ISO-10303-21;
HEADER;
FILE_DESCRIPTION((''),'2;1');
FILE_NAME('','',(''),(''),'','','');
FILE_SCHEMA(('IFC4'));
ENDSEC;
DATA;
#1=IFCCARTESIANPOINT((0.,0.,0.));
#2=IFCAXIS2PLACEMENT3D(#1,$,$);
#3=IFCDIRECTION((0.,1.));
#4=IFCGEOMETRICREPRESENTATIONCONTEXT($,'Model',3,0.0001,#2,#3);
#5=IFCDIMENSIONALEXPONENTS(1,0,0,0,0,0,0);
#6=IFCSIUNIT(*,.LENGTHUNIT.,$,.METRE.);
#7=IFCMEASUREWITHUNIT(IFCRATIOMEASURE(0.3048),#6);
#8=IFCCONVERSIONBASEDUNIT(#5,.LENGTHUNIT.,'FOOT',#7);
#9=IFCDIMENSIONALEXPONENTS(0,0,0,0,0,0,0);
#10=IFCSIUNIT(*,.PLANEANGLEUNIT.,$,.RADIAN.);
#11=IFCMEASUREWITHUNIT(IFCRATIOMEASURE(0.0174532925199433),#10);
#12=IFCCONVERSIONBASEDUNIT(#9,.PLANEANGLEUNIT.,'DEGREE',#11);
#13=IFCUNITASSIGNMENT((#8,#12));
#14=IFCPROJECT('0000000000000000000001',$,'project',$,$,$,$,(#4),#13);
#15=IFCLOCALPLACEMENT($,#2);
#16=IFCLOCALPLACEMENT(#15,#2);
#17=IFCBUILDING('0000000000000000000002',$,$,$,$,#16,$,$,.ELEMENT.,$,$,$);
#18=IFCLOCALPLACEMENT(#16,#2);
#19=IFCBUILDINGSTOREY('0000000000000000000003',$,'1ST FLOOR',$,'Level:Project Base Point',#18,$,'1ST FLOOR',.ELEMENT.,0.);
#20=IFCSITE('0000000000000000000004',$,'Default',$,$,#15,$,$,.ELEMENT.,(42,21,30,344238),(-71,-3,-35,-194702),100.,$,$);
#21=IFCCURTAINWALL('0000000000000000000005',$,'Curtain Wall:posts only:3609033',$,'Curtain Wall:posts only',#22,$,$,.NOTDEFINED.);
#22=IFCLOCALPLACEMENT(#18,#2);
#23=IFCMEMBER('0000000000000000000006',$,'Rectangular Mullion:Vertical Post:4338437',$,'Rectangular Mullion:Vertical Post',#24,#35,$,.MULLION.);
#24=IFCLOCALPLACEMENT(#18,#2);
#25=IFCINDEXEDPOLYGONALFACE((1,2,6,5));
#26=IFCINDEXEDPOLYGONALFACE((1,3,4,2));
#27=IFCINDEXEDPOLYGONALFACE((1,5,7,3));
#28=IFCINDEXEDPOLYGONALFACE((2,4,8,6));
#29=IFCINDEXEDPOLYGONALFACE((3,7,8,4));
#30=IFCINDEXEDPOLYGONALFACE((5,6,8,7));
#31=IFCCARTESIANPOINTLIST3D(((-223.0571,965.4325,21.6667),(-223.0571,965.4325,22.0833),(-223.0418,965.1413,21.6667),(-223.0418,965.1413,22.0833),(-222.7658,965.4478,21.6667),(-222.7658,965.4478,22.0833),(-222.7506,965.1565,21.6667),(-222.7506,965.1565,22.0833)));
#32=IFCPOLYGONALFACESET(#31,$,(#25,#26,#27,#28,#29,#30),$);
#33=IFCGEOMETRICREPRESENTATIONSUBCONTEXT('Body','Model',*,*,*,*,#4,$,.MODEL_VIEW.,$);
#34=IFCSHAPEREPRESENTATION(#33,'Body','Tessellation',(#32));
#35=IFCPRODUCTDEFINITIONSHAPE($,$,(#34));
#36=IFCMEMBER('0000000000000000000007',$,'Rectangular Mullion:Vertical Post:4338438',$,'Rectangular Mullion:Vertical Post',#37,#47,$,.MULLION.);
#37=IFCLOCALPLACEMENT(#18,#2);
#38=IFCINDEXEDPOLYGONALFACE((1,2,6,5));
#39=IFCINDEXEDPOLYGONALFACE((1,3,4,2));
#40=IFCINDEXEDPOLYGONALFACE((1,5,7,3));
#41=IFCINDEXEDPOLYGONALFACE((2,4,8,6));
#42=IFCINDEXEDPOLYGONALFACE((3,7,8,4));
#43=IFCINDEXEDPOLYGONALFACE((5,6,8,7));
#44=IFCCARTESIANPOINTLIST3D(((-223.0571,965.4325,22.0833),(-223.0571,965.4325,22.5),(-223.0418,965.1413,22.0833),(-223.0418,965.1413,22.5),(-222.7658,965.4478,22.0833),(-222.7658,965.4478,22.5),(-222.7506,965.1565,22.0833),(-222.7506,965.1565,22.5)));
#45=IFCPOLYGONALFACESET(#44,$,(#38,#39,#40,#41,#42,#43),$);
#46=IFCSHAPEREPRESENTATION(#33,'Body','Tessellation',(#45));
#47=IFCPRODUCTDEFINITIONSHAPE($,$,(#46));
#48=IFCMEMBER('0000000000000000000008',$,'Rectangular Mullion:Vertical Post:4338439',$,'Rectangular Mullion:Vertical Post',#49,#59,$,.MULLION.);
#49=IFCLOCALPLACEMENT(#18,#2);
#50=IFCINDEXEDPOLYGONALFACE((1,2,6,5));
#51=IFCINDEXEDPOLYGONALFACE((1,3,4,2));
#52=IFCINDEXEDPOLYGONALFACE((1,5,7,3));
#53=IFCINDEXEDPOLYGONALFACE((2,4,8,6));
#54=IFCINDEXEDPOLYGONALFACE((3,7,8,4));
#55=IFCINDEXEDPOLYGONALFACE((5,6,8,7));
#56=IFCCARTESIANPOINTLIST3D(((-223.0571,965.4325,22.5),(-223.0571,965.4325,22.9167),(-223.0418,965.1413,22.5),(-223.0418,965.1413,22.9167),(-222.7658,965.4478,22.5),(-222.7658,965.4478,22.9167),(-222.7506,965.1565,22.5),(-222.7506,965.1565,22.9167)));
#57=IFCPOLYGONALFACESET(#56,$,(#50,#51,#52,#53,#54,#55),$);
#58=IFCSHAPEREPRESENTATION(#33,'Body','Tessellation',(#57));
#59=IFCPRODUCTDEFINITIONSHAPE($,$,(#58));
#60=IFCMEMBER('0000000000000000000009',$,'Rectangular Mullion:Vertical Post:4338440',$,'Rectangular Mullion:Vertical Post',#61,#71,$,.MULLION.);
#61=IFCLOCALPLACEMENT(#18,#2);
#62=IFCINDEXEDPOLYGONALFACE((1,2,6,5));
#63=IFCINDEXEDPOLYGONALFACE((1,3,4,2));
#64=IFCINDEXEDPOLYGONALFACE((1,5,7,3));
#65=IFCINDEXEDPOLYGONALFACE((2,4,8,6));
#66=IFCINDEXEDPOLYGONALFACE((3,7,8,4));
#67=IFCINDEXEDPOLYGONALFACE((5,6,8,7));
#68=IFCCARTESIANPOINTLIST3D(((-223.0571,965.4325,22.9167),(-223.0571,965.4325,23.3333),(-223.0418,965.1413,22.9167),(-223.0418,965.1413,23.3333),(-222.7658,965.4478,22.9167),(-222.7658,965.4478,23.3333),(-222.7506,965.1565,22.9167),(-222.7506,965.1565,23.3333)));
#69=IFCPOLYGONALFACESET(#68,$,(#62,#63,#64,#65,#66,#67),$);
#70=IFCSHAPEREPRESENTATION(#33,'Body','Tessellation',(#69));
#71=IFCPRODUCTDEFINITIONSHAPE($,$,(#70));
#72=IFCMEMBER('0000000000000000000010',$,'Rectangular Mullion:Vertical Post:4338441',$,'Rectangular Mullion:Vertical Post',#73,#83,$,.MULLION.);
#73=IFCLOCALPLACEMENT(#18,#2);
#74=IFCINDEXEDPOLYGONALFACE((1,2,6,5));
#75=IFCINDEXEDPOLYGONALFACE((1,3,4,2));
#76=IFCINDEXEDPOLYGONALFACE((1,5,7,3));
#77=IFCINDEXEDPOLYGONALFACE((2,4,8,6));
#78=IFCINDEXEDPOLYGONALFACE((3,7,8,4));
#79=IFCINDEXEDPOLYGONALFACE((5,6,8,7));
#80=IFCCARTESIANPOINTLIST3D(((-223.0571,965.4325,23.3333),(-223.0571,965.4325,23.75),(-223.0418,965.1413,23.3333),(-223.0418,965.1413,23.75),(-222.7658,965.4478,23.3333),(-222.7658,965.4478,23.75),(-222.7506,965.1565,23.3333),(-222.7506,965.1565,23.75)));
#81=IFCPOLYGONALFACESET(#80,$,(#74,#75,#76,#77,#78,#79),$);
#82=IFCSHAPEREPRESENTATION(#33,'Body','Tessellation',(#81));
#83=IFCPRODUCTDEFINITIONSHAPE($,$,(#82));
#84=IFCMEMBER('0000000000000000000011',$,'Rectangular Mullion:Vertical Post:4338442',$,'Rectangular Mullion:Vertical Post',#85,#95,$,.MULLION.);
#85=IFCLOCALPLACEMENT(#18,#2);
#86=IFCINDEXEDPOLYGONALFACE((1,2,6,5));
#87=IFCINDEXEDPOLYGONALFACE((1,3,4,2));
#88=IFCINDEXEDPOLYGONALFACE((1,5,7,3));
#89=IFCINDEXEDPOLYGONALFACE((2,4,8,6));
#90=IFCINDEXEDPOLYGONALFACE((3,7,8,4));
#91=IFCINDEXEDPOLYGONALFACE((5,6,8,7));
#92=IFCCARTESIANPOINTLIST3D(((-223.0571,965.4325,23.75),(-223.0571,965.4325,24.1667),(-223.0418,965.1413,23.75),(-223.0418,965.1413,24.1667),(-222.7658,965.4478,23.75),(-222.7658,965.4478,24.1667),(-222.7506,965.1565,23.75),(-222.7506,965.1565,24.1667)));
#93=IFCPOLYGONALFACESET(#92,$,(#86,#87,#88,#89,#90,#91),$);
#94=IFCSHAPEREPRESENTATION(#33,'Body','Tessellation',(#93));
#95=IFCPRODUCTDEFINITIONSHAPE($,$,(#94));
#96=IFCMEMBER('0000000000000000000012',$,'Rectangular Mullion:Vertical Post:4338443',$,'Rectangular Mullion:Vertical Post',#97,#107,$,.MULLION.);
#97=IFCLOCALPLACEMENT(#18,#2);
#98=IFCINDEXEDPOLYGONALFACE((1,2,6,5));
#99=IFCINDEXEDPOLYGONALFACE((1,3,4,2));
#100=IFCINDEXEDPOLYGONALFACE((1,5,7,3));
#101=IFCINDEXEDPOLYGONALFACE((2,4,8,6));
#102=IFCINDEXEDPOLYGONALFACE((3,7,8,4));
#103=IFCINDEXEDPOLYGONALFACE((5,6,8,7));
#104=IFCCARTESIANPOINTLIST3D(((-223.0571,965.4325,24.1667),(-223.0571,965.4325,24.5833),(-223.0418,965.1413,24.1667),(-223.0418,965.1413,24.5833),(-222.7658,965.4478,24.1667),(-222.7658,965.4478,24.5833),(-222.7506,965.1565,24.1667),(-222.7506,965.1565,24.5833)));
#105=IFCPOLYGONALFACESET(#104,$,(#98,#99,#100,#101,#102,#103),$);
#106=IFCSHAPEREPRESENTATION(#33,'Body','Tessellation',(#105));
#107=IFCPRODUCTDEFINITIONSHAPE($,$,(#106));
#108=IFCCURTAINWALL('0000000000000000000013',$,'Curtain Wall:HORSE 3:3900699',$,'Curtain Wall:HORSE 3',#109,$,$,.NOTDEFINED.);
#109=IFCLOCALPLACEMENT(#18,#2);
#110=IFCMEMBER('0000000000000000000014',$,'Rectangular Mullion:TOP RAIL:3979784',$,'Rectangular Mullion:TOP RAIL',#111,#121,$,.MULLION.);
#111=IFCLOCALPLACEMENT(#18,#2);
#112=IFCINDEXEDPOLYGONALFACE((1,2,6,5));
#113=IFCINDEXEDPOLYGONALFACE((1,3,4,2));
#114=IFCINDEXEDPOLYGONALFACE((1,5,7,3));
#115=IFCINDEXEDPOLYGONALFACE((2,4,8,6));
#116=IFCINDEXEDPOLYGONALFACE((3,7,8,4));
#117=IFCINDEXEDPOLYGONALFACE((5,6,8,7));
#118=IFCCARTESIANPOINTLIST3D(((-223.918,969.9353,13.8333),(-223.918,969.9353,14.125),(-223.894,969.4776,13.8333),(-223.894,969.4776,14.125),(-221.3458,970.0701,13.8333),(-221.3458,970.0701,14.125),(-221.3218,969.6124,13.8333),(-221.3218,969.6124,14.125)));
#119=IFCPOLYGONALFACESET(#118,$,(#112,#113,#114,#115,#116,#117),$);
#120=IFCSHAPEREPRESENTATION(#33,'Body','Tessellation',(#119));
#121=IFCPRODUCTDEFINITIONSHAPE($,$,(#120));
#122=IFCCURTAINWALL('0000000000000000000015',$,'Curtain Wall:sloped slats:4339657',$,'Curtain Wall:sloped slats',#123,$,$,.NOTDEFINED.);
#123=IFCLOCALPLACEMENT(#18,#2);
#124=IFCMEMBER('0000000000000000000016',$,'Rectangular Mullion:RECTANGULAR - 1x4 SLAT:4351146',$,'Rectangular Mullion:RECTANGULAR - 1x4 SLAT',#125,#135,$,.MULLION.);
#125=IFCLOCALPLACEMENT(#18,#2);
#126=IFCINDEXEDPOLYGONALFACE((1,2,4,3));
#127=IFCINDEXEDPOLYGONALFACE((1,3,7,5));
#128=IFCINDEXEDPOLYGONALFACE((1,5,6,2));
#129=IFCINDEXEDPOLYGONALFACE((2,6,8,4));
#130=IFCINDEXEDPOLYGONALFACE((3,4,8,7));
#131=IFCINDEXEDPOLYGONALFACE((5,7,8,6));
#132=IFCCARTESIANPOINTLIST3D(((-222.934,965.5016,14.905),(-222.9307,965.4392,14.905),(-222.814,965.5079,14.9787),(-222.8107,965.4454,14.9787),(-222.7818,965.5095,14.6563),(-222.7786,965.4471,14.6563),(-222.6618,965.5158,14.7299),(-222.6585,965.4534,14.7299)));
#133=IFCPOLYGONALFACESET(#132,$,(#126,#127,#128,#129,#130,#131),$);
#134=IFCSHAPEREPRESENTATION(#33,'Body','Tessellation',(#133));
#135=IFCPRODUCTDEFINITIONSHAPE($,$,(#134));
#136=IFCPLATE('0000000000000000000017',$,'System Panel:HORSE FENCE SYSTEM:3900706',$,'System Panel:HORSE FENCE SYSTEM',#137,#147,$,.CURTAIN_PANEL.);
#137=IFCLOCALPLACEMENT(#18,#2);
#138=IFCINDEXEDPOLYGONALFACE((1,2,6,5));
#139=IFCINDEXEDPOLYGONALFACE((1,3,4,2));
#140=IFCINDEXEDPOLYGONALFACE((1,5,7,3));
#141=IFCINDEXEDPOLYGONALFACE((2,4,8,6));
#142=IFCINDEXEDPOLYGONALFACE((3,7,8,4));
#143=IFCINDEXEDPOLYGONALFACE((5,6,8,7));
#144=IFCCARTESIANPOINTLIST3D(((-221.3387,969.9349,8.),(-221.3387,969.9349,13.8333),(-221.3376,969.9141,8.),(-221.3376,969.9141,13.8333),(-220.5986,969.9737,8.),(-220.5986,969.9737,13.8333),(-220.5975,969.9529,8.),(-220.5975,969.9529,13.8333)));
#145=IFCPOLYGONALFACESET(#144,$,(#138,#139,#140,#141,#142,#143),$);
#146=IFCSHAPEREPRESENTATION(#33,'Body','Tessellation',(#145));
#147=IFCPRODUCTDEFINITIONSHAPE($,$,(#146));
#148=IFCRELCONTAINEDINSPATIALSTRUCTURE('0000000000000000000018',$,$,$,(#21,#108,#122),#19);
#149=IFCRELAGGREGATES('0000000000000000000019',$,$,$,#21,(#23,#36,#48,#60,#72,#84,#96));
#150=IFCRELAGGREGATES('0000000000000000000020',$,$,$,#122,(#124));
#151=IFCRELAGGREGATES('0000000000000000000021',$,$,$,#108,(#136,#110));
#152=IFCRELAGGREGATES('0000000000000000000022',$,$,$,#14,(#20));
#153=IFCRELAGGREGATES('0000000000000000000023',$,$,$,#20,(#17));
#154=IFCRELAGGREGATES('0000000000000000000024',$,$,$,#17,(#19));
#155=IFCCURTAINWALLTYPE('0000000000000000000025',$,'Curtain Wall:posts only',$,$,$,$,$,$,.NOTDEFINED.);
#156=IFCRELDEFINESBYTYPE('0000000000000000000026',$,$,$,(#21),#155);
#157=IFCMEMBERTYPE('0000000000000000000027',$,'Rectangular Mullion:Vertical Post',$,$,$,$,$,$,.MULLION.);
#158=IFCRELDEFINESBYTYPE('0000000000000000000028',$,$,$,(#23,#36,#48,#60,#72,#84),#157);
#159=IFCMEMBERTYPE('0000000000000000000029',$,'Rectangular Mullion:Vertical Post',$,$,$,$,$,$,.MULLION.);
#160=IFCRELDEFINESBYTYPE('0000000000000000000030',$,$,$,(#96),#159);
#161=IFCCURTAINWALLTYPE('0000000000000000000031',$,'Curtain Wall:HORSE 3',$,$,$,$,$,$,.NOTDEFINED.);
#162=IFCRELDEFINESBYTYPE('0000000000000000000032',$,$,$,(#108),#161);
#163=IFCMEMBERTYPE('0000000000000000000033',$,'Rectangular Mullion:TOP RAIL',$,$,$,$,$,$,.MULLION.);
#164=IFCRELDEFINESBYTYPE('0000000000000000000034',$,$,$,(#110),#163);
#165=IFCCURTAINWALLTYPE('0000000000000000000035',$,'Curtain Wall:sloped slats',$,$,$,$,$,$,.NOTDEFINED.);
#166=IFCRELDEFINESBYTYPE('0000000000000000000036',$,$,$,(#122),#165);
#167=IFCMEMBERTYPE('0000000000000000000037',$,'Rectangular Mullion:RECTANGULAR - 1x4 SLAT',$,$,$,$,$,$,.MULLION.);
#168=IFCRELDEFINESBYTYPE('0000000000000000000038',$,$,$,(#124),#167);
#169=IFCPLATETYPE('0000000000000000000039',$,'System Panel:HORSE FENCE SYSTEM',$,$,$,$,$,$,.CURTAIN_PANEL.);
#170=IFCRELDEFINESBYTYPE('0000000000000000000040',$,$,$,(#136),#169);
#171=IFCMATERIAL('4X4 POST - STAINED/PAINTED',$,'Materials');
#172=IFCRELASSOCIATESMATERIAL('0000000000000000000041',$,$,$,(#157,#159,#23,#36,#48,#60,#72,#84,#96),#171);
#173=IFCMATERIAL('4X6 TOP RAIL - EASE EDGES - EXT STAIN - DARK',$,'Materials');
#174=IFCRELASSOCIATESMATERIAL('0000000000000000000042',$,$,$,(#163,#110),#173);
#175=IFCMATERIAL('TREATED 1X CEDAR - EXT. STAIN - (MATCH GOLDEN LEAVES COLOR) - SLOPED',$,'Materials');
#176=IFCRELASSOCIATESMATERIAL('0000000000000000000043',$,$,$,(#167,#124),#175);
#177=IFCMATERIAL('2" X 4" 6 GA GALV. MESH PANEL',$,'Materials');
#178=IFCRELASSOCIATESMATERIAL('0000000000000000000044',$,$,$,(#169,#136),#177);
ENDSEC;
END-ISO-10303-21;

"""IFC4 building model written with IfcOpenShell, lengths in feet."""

from ifc_helpers import new_model, entity, si_unit, converted_unit, direction, frame, frame_2d, origin, origin_2d_with_axis, place, context, subcontext, project, spatial, rectangle, extrude, source, transform, mapped, material, material_profile, profile_set, profile_usage, type_object, type_shapes, element, aggregate, save


model = new_model("IFC4")

# Units and contexts
model_context = context("Model", 3, precision=0.0001, world=origin(), true_north=direction((0.0, 1.0)))
body_context = subcontext(model_context, "Body", "Model", "MODEL_VIEW")
ifc_project = project(units=[converted_unit("LENGTHUNIT", "FOOT", entity("IfcRatioMeasure", 0.3048), si_unit("LENGTHUNIT", "METRE"), dimensions=[1, 0, 0, 0, 0, 0, 0]), converted_unit("PLANEANGLEUNIT", "DEGREE", entity("IfcRatioMeasure", 0.0174532925199433), si_unit("PLANEANGLEUNIT", "RADIAN"), dimensions=[0, 0, 0, 0, 0, 0, 0])], contexts=[model_context])

# Site, building, storey
site_placement = place(None, origin())
site = spatial("IfcSite", under=ifc_project, at=site_placement, Name="Default", CompositionType="ELEMENT", RefLatitude=(42, 21, 30, 344238), RefLongitude=(-71, -3, -35, -194702), RefElevation=100.0)
building_placement = place(site_placement, origin())
building = spatial("IfcBuilding", under=site, at=building_placement, CompositionType="ELEMENT")
storey_placement = place(building_placement, origin())
storey = spatial("IfcBuildingStorey", under=building, at=storey_placement, Name="1ST FLOOR", ObjectType="Level:Project Base Point", LongName="1ST FLOOR", CompositionType="ELEMENT", Elevation=0.0)

# Curtain wall, members
curtain_wall_type_1 = type_object("IfcCurtainWallType", Name="Curtain Wall:posts only", PredefinedType="NOTDEFINED")
curtain_wall_1_placement = place(storey_placement, origin())
curtain_wall_1 = element("IfcCurtainWall", 1, at=curtain_wall_1_placement, inside=storey, type_object=curtain_wall_type_1, Name="Curtain Wall:posts only:3609033", ObjectType="Curtain Wall:posts only", PredefinedType="NOTDEFINED")
ifc_material_1 = material(Name="4X4 POST - STAINED/PAINTED", Category="Materials")
ifc_material_profile_1 = material_profile(ifc_material_1, rectangle(XDim=0.2917, YDim=0.2917, at=origin_2d_with_axis()), Name="Vertical Post")
ifc_profile_set_1 = profile_set([ifc_material_profile_1], Name="Vertical Post")
member_type_1 = type_object("IfcMemberType", Name="Rectangular Mullion:Vertical Post", PredefinedType="MULLION", material=ifc_profile_set_1)
shared_shape_1 = source(origin(), body_context, "Body", "SweptSolid", [
    extrude(rectangle(XDim=0.2917, YDim=0.2917, at=origin_2d_with_axis()), frame((0.0, -0.2083, -0.4167), z_axis=(0.0, 0.0, 1.0), x_axis=(0.0, -1.0, 0.0)), (0.0, 0.0, 1.0), 0.4167),
])
type_shapes(member_type_1, [shared_shape_1])
ifc_profile_usage_1 = profile_usage(ifc_profile_set_1)
member_1_placement = place(storey_placement, frame((-222.9147, 965.5026, 21.6667), z_axis=(0.0, 0.0, -1.0), x_axis=(-0.99863, -0.052336, 0.0)))
member_1 = element("IfcMember", 2, at=member_1_placement, type_object=member_type_1, material=ifc_profile_usage_1, Name="Rectangular Mullion:Vertical Post:4338437", ObjectType="Rectangular Mullion:Vertical Post", PredefinedType="MULLION", context=body_context, shape_type="MappedRepresentation", body=[
    mapped(shared_shape_1, transform((0.0, 0.0, 0.0), scale=1.0)),
])
ifc_profile_usage_2 = profile_usage(ifc_profile_set_1)
member_2_placement = place(storey_placement, frame((-222.9147, 965.5026, 22.0833), z_axis=(0.0, 0.0, -1.0), x_axis=(-0.99863, -0.052336, 0.0)))
member_2 = element("IfcMember", 3, at=member_2_placement, type_object=member_type_1, material=ifc_profile_usage_2, Name="Rectangular Mullion:Vertical Post:4338438", ObjectType="Rectangular Mullion:Vertical Post", PredefinedType="MULLION", context=body_context, shape_type="MappedRepresentation", body=[
    mapped(shared_shape_1, transform((0.0, 0.0, 0.0), scale=1.0)),
])
ifc_profile_usage_3 = profile_usage(ifc_profile_set_1)
member_3_placement = place(storey_placement, frame((-222.9147, 965.5026, 22.5), z_axis=(0.0, 0.0, -1.0), x_axis=(-0.99863, -0.052336, 0.0)))
member_3 = element("IfcMember", 4, at=member_3_placement, type_object=member_type_1, material=ifc_profile_usage_3, Name="Rectangular Mullion:Vertical Post:4338439", ObjectType="Rectangular Mullion:Vertical Post", PredefinedType="MULLION", context=body_context, shape_type="MappedRepresentation", body=[
    mapped(shared_shape_1, transform((0.0, 0.0, 0.0), scale=1.0)),
])
ifc_profile_usage_4 = profile_usage(ifc_profile_set_1)
member_4_placement = place(storey_placement, frame((-222.9147, 965.5026, 22.9167), z_axis=(0.0, 0.0, -1.0), x_axis=(-0.99863, -0.052336, 0.0)))
member_4 = element("IfcMember", 5, at=member_4_placement, type_object=member_type_1, material=ifc_profile_usage_4, Name="Rectangular Mullion:Vertical Post:4338440", ObjectType="Rectangular Mullion:Vertical Post", PredefinedType="MULLION", context=body_context, shape_type="MappedRepresentation", body=[
    mapped(shared_shape_1, transform((0.0, 0.0, 0.0), scale=1.0)),
])
ifc_profile_usage_5 = profile_usage(ifc_profile_set_1)
member_5_placement = place(storey_placement, frame((-222.9147, 965.5026, 23.3333), z_axis=(0.0, 0.0, -1.0), x_axis=(-0.99863, -0.052336, 0.0)))
member_5 = element("IfcMember", 6, at=member_5_placement, type_object=member_type_1, material=ifc_profile_usage_5, Name="Rectangular Mullion:Vertical Post:4338441", ObjectType="Rectangular Mullion:Vertical Post", PredefinedType="MULLION", context=body_context, shape_type="MappedRepresentation", body=[
    mapped(shared_shape_1, transform((0.0, 0.0, 0.0), scale=1.0)),
])
ifc_profile_usage_6 = profile_usage(ifc_profile_set_1)
member_6_placement = place(storey_placement, frame((-222.9147, 965.5026, 23.75), z_axis=(0.0, 0.0, -1.0), x_axis=(-0.99863, -0.052336, 0.0)))
member_6 = element("IfcMember", 7, at=member_6_placement, type_object=member_type_1, material=ifc_profile_usage_6, Name="Rectangular Mullion:Vertical Post:4338442", ObjectType="Rectangular Mullion:Vertical Post", PredefinedType="MULLION", context=body_context, shape_type="MappedRepresentation", body=[
    mapped(shared_shape_1, transform((0.0, 0.0, 0.0), scale=1.0)),
])
ifc_profile_usage_7 = profile_usage(ifc_profile_set_1)
member_type_2 = type_object("IfcMemberType", Name="Rectangular Mullion:Vertical Post", PredefinedType="MULLION", material=ifc_profile_set_1)
shared_shape_2 = source(origin(), body_context, "Body", "SweptSolid", [
    extrude(rectangle(XDim=0.2917, YDim=0.2917, at=origin_2d_with_axis()), frame((0.0, -0.2083, -0.4167), z_axis=(0.0, 0.0, 1.0), x_axis=(0.0, -1.0, 0.0)), (0.0, 0.0, 1.0), 0.4167),
])
type_shapes(member_type_2, [shared_shape_2])
member_7_placement = place(storey_placement, frame((-222.9147, 965.5026, 24.1667), z_axis=(0.0, 0.0, -1.0), x_axis=(-0.99863, -0.052336, 0.0)))
member_7 = element("IfcMember", 8, at=member_7_placement, type_object=member_type_2, material=ifc_profile_usage_7, Name="Rectangular Mullion:Vertical Post:4338443", ObjectType="Rectangular Mullion:Vertical Post", PredefinedType="MULLION", context=body_context, shape_type="MappedRepresentation", body=[
    mapped(shared_shape_2, transform((0.0, 0.0, 0.0), scale=1.0)),
])
aggregate(curtain_wall_1, [member_1, member_2, member_3, member_4, member_5, member_6, member_7])

# Curtain walls, members
curtain_wall_type_2 = type_object("IfcCurtainWallType", Name="Curtain Wall:HORSE 3", PredefinedType="NOTDEFINED")
curtain_wall_2_placement = place(storey_placement, origin())
curtain_wall_2 = element("IfcCurtainWall", 9, at=curtain_wall_2_placement, inside=storey, type_object=curtain_wall_type_2, Name="Curtain Wall:HORSE 3:3900699", ObjectType="Curtain Wall:HORSE 3", PredefinedType="NOTDEFINED")
ifc_material_2 = material(Name="4X6 TOP RAIL - EASE EDGES - EXT STAIN - DARK", Category="Materials")
ifc_material_profile_2 = material_profile(ifc_material_2, rectangle(XDim=0.4583, YDim=0.2917, at=origin_2d_with_axis()), Name="TOP RAIL")
ifc_profile_set_2 = profile_set([ifc_material_profile_2], Name="TOP RAIL")
ifc_profile_usage_8 = profile_usage(ifc_profile_set_2)
member_type_3 = type_object("IfcMemberType", Name="Rectangular Mullion:TOP RAIL", PredefinedType="MULLION", material=ifc_profile_set_2)
shared_shape_3 = source(origin(), body_context, "Body", "SweptSolid", [
    extrude(rectangle(XDim=0.4583, YDim=0.2917, at=origin_2d_with_axis()), frame((-0.1458, -0.0625, -2.5758), z_axis=(0.0, 0.0, 1.0), x_axis=(0.0, -1.0, 0.0)), (0.0, 0.0, 1.0), 2.5758),
])
type_shapes(member_type_3, [shared_shape_3])
member_8_placement = place(storey_placement, frame((-221.3305, 969.7789, 14.125), z_axis=(0.99863, 0.052336, 0.0), x_axis=(0.0, 0.0, 1.0)))
member_8 = element("IfcMember", 10, at=member_8_placement, type_object=member_type_3, material=ifc_profile_usage_8, Name="Rectangular Mullion:TOP RAIL:3979784", ObjectType="Rectangular Mullion:TOP RAIL", PredefinedType="MULLION", context=body_context, shape_type="MappedRepresentation", body=[
    mapped(shared_shape_3, transform((0.0, 0.0, 0.0), scale=1.0)),
])
curtain_wall_type_3 = type_object("IfcCurtainWallType", Name="Curtain Wall:sloped slats", PredefinedType="NOTDEFINED")
curtain_wall_3_placement = place(storey_placement, origin())
curtain_wall_3 = element("IfcCurtainWall", 11, at=curtain_wall_3_placement, inside=storey, type_object=curtain_wall_type_3, Name="Curtain Wall:sloped slats:4339657", ObjectType="Curtain Wall:sloped slats", PredefinedType="NOTDEFINED")
ifc_material_3 = material(Name="TREATED 1X CEDAR - EXT. STAIN - (MATCH GOLDEN LEAVES COLOR) - SLOPED", Category="Materials")
ifc_material_profile_3 = material_profile(ifc_material_3, rectangle(XDim=0.0625, YDim=0.2917, at=frame_2d((0.0, 0.0), x_axis=(1.0, 0.0))), Name="RECTANGULAR - 1x4 SLAT")
ifc_profile_set_3 = profile_set([ifc_material_profile_3], Name="RECTANGULAR - 1x4 SLAT")
ifc_profile_usage_9 = profile_usage(ifc_profile_set_3)
member_type_4 = type_object("IfcMemberType", Name="Rectangular Mullion:RECTANGULAR - 1x4 SLAT", PredefinedType="MULLION", material=ifc_profile_set_3)
shared_shape_4 = source(origin(), body_context, "Body", "SweptSolid", [
    extrude(rectangle(XDim=0.0625, YDim=0.2917, at=origin_2d_with_axis()), frame((0.0, 0.0, -0.141), z_axis=(0.0, 0.0, 1.0), x_axis=(0.0, -1.0, 0.0)), (0.0, 0.0, 1.0), 0.141),
])
type_shapes(member_type_4, [shared_shape_4])
member_9_placement = place(storey_placement, frame((-222.8563, 965.4744, 14.7807), z_axis=(-0.851559, -0.044628, -0.522356), x_axis=(-0.52164, -0.027338, 0.852727)))
member_9 = element("IfcMember", 12, at=member_9_placement, type_object=member_type_4, material=ifc_profile_usage_9, Name="Rectangular Mullion:RECTANGULAR - 1x4 SLAT:4351146", ObjectType="Rectangular Mullion:RECTANGULAR - 1x4 SLAT", PredefinedType="MULLION", context=body_context, shape_type="MappedRepresentation", body=[
    mapped(shared_shape_4, transform((0.0, 0.0, 0.0), scale=1.0)),
])
aggregate(curtain_wall_3, [member_9])

# Plate
ifc_material_4 = material(Name="2\" X 4\" 6 GA GALV. MESH PANEL", Category="Materials")
plate_type_1 = type_object("IfcPlateType", Name="System Panel:HORSE FENCE SYSTEM", PredefinedType="CURTAIN_PANEL", material=ifc_material_4)
shared_shape_5 = source(origin(), body_context, "Body", "SweptSolid", [
    extrude(rectangle(XDim=0.0208, YDim=0.7411, at=frame_2d((0.0, 0.0), x_axis=(1.0, 0.0))), frame((0.3706, 0.0104, 0.0), z_axis=(0.0, 0.0, 1.0), x_axis=(0.0, 1.0, 0.0)), (0.0, 0.0, 1.0), 5.8333),
])
type_shapes(plate_type_1, [shared_shape_5])
plate_1_placement = place(curtain_wall_2_placement, frame((-221.3376, 969.9141, 8.0), z_axis=(0.0, 0.0, 1.0), x_axis=(0.99863, 0.052336, 0.0)))
plate_1 = element("IfcPlate", 13, at=plate_1_placement, type_object=plate_type_1, material=ifc_material_4, Name="System Panel:HORSE FENCE SYSTEM:3900706", ObjectType="System Panel:HORSE FENCE SYSTEM", PredefinedType="CURTAIN_PANEL", context=body_context, shape_type="MappedRepresentation", body=[
    mapped(shared_shape_5, transform((0.0, 0.0, 0.0), scale=1.0)),
])
aggregate(curtain_wall_2, [plate_1, member_8])

save(model, "model.ifc")
